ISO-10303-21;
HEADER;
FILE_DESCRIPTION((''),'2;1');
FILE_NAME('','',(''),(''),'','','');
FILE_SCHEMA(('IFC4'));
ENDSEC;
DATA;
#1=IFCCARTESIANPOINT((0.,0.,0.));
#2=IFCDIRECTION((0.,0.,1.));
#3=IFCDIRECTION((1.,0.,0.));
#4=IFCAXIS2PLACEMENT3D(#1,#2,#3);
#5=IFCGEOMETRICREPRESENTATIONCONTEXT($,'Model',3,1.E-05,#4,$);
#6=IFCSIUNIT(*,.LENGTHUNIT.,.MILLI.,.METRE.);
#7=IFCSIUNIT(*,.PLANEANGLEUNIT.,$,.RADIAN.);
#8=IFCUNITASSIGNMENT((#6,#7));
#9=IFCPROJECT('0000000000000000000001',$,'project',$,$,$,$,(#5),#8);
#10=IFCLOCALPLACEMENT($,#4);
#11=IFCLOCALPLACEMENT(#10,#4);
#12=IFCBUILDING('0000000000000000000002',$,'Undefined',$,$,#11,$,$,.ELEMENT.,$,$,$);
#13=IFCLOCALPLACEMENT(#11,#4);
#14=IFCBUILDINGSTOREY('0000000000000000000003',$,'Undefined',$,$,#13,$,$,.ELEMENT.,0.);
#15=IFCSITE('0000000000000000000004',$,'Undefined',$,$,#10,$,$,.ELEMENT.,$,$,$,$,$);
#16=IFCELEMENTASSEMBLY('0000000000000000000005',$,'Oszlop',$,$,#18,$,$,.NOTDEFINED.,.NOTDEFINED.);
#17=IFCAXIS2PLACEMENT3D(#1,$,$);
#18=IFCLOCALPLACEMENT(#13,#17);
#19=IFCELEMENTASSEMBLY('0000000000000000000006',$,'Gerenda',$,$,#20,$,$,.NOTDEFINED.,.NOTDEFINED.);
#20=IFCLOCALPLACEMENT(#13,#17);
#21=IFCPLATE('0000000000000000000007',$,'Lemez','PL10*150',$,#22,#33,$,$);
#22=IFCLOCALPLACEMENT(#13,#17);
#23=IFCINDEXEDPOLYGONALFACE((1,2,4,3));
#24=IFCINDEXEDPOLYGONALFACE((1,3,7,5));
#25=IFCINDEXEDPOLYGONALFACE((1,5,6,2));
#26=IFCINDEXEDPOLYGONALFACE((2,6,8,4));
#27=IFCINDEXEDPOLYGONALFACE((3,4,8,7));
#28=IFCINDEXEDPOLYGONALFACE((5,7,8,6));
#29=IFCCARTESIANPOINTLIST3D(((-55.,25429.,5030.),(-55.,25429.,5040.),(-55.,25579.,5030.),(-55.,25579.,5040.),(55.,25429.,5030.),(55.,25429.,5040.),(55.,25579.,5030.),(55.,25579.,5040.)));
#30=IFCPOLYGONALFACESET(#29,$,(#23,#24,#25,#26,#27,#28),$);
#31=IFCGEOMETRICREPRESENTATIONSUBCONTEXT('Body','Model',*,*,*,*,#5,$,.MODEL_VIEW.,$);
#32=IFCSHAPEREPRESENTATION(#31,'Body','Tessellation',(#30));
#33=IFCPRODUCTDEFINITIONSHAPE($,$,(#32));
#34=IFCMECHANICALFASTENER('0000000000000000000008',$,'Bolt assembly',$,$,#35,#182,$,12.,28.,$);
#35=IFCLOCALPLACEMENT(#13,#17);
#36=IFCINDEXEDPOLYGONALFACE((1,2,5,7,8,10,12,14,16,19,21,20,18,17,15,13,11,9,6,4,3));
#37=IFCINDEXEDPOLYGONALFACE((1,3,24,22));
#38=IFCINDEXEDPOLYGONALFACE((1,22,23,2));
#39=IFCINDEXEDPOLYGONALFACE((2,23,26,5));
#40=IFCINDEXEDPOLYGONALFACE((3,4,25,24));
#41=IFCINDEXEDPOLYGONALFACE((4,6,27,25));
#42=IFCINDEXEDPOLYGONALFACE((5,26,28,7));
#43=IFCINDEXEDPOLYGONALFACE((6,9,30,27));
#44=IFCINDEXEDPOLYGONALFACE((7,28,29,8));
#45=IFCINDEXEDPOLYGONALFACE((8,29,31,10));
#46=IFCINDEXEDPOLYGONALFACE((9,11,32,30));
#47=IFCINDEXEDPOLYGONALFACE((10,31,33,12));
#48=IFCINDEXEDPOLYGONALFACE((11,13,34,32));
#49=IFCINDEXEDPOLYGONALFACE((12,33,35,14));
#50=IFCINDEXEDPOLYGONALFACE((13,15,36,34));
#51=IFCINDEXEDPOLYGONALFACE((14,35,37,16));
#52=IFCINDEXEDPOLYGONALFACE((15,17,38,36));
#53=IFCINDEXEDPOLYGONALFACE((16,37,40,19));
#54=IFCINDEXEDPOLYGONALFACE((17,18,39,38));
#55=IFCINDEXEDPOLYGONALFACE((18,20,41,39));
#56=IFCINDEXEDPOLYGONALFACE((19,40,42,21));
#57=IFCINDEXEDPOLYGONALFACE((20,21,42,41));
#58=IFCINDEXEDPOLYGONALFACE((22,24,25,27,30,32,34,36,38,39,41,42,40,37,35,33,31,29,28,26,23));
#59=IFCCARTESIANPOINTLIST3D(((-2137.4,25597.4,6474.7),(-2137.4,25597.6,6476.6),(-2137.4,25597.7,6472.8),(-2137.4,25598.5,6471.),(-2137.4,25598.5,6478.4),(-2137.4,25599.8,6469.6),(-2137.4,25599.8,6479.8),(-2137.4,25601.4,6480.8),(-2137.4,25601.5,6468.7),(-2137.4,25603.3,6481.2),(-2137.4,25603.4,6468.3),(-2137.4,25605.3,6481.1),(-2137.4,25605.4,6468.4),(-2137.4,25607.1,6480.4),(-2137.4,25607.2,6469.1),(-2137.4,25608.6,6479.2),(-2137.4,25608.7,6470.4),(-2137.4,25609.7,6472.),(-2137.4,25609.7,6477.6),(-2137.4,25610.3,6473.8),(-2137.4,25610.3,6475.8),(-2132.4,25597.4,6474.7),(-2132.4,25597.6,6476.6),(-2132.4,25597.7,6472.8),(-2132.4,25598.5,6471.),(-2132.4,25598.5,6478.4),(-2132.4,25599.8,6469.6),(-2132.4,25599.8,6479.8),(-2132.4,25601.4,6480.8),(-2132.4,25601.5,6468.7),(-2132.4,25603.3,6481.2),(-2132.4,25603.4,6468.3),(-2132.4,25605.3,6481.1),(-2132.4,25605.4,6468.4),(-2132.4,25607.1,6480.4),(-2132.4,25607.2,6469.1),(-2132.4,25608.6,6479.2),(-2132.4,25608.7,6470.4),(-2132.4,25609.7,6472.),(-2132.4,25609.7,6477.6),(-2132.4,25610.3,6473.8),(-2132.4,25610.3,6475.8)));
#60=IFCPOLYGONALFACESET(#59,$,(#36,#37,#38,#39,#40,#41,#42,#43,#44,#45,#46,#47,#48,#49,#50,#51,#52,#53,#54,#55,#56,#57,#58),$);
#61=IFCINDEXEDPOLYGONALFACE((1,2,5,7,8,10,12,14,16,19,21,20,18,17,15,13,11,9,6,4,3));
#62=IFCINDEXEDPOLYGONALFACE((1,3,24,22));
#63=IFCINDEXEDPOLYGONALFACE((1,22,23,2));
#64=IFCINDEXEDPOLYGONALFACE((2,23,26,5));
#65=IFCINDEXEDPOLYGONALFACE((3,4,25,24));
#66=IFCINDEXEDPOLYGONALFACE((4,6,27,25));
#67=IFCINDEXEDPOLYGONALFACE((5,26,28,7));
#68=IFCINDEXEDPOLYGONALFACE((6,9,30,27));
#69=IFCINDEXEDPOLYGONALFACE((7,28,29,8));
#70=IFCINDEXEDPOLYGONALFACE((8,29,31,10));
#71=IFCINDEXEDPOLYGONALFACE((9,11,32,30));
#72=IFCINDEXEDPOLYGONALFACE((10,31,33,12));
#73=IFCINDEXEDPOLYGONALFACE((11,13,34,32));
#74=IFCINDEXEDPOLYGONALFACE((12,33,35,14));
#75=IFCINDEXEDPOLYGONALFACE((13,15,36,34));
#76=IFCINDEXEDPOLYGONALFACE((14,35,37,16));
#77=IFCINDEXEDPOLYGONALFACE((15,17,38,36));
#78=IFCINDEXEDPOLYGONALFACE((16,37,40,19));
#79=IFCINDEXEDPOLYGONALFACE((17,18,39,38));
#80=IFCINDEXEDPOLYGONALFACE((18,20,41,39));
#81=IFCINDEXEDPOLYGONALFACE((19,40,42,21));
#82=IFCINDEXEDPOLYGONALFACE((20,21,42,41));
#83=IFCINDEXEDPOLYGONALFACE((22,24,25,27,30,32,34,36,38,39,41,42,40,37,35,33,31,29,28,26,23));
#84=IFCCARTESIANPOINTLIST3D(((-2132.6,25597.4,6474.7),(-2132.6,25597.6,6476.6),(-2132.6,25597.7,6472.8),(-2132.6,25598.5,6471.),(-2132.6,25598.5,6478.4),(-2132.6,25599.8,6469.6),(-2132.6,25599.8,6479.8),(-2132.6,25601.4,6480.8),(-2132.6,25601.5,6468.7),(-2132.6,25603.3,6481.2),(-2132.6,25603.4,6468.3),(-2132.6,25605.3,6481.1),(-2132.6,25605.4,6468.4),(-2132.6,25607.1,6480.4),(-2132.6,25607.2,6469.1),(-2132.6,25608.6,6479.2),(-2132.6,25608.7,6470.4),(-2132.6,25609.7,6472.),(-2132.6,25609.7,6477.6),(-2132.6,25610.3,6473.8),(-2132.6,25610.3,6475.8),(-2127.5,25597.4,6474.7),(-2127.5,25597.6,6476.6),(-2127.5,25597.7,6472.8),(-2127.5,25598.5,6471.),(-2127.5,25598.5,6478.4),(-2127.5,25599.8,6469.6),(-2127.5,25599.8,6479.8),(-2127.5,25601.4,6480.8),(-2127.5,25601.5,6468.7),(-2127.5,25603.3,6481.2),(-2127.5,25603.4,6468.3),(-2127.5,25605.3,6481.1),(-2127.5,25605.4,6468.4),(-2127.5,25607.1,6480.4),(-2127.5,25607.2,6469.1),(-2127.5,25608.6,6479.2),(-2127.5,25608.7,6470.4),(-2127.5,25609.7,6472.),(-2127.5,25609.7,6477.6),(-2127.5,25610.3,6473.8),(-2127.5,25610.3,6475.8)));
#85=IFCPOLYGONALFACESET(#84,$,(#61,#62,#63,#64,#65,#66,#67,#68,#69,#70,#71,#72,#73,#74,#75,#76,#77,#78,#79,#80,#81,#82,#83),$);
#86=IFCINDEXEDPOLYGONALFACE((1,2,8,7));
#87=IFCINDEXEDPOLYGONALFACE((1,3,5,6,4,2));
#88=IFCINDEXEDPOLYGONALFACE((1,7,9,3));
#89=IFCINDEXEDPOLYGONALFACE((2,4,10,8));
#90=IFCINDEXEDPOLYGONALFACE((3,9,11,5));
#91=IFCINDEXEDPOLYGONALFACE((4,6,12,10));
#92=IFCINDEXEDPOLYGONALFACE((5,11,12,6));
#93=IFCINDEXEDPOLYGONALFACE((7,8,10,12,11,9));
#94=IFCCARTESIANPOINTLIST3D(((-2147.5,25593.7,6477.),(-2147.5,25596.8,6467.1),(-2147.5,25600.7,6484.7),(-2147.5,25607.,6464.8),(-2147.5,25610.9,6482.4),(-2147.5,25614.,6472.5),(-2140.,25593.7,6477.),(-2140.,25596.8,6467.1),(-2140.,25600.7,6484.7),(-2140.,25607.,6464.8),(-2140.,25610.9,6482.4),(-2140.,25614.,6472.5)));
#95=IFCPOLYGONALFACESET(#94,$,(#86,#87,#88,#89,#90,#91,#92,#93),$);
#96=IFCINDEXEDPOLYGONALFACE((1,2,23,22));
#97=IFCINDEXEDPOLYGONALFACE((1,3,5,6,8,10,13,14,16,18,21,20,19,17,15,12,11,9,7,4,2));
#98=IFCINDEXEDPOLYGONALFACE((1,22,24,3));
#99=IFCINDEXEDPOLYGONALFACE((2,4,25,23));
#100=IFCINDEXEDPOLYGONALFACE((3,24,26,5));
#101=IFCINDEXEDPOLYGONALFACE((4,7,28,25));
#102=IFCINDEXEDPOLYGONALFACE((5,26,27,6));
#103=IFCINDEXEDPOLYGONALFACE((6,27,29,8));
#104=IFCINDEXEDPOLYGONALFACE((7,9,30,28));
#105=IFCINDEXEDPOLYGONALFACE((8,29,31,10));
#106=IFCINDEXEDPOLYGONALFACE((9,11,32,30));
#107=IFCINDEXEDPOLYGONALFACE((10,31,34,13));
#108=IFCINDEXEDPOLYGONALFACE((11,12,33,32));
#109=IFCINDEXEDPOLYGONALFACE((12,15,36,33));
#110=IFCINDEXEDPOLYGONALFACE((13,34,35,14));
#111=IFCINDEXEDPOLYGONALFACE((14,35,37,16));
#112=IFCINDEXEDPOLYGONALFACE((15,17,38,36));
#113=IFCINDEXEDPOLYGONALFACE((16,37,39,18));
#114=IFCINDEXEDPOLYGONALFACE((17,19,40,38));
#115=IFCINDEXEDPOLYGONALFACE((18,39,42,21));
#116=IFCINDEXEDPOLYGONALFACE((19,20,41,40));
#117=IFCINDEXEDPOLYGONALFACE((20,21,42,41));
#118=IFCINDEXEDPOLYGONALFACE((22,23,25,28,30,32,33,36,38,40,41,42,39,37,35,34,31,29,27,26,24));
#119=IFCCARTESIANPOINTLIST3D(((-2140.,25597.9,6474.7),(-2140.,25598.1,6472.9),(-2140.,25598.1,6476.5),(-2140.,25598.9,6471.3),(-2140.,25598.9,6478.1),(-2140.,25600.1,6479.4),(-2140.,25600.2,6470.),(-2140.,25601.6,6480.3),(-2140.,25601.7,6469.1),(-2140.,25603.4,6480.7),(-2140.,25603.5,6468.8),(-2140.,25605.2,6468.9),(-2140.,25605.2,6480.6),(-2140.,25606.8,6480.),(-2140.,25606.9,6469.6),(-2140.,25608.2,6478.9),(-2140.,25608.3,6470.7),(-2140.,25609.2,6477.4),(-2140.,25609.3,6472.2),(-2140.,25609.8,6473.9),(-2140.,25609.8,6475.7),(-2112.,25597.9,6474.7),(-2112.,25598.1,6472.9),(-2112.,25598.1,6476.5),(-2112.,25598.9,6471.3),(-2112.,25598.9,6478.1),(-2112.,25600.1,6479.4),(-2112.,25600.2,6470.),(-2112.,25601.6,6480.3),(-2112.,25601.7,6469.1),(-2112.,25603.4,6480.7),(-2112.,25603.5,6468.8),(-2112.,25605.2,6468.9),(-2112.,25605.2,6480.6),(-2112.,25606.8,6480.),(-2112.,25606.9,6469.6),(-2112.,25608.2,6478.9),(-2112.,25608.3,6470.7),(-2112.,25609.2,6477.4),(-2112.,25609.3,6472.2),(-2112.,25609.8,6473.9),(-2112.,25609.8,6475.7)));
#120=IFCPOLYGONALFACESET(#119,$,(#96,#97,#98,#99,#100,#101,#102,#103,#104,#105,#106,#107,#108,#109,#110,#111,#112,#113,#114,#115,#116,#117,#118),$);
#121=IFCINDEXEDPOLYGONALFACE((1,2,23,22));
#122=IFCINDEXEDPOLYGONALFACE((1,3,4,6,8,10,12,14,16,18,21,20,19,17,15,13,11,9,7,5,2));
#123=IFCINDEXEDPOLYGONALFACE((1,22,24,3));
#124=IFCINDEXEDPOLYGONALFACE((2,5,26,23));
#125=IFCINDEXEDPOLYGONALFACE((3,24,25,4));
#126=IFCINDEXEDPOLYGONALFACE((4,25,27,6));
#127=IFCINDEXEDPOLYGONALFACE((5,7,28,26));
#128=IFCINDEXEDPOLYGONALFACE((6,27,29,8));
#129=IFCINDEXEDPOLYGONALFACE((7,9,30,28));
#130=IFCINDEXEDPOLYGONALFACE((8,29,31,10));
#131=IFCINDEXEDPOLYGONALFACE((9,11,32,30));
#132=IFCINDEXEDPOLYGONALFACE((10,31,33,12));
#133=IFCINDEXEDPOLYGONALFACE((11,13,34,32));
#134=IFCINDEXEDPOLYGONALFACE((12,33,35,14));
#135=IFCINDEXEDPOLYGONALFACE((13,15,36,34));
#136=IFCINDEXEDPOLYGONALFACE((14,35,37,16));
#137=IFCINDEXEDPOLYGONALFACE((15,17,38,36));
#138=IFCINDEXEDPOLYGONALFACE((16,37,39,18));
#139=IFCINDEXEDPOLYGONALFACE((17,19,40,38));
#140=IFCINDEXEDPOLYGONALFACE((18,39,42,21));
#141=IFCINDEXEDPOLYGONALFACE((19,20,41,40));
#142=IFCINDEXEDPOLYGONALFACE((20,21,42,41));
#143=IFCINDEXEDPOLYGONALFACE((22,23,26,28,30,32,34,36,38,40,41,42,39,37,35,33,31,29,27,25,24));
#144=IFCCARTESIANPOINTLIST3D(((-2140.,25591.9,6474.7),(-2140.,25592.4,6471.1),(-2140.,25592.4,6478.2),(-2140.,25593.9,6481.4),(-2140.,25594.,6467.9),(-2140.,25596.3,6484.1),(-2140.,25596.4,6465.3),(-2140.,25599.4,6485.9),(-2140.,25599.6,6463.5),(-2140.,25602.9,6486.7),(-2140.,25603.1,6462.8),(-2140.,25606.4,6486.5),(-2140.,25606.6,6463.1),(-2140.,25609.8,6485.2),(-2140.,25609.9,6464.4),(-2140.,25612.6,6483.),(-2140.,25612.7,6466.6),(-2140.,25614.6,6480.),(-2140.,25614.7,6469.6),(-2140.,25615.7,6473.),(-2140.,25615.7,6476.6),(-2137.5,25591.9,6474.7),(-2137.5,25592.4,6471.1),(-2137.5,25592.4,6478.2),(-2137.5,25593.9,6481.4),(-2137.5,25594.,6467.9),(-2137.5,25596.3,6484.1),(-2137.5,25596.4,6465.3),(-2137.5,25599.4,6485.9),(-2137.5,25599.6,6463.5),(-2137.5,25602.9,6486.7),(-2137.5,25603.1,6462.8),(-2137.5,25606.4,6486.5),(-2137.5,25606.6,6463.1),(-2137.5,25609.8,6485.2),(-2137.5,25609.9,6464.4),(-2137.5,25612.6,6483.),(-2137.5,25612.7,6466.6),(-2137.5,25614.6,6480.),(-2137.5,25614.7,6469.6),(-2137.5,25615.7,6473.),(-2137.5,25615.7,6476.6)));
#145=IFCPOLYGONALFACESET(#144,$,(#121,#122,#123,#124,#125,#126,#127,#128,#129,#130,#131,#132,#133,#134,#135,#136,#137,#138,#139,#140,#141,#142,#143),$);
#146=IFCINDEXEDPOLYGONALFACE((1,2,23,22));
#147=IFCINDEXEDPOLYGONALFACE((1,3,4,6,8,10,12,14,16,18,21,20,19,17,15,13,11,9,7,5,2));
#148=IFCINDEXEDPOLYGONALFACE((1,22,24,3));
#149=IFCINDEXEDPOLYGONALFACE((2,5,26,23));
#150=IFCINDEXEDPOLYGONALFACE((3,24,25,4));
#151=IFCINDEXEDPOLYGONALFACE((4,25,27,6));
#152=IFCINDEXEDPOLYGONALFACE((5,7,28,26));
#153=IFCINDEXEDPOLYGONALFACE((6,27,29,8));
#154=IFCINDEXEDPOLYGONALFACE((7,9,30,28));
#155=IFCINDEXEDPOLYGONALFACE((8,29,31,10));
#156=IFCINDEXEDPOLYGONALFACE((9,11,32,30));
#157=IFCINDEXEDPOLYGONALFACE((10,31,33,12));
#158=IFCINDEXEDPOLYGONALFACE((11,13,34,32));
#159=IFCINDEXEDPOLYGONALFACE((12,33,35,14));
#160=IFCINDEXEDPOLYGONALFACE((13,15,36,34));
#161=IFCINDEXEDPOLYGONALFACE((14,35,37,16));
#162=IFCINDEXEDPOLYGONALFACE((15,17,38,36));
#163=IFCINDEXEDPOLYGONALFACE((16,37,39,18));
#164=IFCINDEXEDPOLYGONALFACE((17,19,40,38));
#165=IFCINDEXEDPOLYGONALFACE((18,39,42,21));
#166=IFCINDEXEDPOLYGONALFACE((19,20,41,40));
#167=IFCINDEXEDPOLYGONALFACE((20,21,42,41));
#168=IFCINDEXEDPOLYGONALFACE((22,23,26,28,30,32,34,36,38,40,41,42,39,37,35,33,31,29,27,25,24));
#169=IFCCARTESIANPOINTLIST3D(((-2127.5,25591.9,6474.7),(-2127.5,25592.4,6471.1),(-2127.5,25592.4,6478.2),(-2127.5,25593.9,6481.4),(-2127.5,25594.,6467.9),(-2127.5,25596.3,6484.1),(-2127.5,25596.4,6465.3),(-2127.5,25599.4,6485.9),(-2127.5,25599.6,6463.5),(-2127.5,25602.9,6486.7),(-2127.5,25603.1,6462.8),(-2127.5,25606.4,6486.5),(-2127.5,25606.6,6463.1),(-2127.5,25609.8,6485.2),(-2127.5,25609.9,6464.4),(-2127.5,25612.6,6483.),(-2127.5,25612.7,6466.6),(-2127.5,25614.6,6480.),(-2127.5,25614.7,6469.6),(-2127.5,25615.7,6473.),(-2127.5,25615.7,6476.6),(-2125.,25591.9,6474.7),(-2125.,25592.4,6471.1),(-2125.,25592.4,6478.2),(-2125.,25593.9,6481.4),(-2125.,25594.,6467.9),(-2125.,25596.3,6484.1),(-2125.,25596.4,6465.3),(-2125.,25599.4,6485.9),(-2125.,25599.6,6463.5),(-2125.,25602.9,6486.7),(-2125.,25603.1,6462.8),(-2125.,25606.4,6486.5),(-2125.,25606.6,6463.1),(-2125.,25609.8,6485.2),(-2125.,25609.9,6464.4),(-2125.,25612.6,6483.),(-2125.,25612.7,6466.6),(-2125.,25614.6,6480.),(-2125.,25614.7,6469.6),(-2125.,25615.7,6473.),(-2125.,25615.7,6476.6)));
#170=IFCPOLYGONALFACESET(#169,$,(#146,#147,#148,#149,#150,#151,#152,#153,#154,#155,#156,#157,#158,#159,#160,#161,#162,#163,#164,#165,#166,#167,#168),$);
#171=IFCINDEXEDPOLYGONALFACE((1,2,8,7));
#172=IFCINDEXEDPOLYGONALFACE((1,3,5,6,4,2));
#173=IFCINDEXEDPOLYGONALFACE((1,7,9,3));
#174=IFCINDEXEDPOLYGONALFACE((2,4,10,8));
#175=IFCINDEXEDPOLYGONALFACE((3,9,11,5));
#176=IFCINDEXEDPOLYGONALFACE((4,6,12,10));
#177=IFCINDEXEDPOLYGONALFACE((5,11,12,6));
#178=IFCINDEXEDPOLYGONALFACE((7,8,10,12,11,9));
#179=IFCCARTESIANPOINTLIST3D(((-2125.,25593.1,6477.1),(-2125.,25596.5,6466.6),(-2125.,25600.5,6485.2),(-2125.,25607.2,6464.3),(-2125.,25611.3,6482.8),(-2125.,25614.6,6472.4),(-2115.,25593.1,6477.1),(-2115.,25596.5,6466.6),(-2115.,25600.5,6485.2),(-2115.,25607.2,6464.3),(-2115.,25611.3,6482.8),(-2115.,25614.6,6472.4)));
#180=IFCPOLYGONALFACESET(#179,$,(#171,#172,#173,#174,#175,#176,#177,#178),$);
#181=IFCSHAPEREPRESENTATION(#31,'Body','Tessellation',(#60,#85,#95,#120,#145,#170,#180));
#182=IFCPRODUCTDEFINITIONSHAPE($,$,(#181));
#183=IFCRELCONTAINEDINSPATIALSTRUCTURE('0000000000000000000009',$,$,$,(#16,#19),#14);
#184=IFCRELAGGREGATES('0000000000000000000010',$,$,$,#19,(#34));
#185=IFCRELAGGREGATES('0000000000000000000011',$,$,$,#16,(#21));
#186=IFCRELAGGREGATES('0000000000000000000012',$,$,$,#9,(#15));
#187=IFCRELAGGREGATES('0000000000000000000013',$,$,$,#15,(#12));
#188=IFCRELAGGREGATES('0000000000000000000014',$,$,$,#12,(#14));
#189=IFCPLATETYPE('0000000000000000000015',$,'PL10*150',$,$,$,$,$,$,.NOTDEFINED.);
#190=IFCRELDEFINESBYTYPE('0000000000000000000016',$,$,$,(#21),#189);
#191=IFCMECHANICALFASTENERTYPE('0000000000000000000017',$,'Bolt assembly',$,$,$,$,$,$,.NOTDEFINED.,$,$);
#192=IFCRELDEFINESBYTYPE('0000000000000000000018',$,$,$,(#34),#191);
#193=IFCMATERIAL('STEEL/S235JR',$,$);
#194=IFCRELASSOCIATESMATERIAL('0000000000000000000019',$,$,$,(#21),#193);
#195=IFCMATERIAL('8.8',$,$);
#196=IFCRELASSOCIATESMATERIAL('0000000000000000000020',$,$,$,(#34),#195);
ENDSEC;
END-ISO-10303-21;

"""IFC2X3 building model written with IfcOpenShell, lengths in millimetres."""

from ifc_helpers import new_model, si_unit, frame, origin_with_axes, origin_2d_with_axis, place, context, subcontext, project, spatial, polyline, circle, outline, extrude, source, transform, mapped, material, type_object, element, aggregate, save


model = new_model("IFC2X3")

# Units and contexts
model_context = context("Model", 3, precision=1e-05, world=origin_with_axes())
body_context = subcontext(model_context, "Body", "Model", "MODEL_VIEW")
ifc_project = project(units=[si_unit("LENGTHUNIT", "METRE", prefix="MILLI"), si_unit("PLANEANGLEUNIT", "RADIAN")], contexts=[model_context])

# Site, building, storey
site_placement = place(None, origin_with_axes())
site = spatial("IfcSite", under=ifc_project, at=site_placement, Name="Undefined", CompositionType="ELEMENT")
building_placement = place(site_placement, origin_with_axes())
building = spatial("IfcBuilding", under=site, at=building_placement, Name="Undefined", CompositionType="ELEMENT")
storey_placement = place(building_placement, origin_with_axes())
storey = spatial("IfcBuildingStorey", under=building, at=storey_placement, Name="Undefined", CompositionType="ELEMENT", Elevation=0.0)

# Element assembly
ifc_material_1 = material(Name="STEEL/S235JR")
assembly_1_placement = place(storey_placement, origin_with_axes())
assembly_1 = element("IfcElementAssembly", 1, at=assembly_1_placement, inside=storey, Name="Oszlop", AssemblyPlace="NOTDEFINED", PredefinedType="NOTDEFINED")

# Element assembly
assembly_2_placement = place(storey_placement, origin_with_axes())
assembly_2 = element("IfcElementAssembly", 2, at=assembly_2_placement, inside=storey, Name="Gerenda", AssemblyPlace="NOTDEFINED", PredefinedType="NOTDEFINED")

# Plate
plate_type_1 = type_object("IfcPlateType", Name="PL10*150", PredefinedType="NOTDEFINED")
plate_1_placement = place(assembly_1_placement, frame((55.0, 25504.0, 5035.0), z_axis=(0.0, 0.0, 1.0), x_axis=(-1.0, 0.0, 0.0)))
plate_1 = element("IfcPlate", 3, at=plate_1_placement, type_object=plate_type_1, material=ifc_material_1, Name="Lemez", Description="PL10*150", context=body_context, shape_type="SweptSolid", body=[
    extrude(outline(polyline([(0.0, -75.0), (0.0, 75.0), (110.0, 75.0), (110.0, -75.0), (0.0, -75.0)])), frame((0.0, 0.0, -5.0), z_axis=(0.0, 0.0, 1.0), x_axis=(1.0, 0.0, 0.0)), (0.0, 0.0, 1.0), 10.0),
])

# Mechanical fastener
ifc_material_2 = material(Name="8.8")
mechanical_fastener_type = type_object("IfcMechanicalFastenerType", Name="Bolt assembly")
shared_shape_1 = source(origin_with_axes(), body_context, "Body", "SweptSolid", [
    extrude(circle(Radius=6.5, at=origin_2d_with_axis()), frame((0.0, -7.4, 0.0), z_axis=(0.0, 1.0, 0.0), x_axis=(1.0, 0.0, 0.0)), (0.0, 0.0, 1.0), 5.0),
    extrude(circle(Radius=6.5, at=origin_2d_with_axis()), frame((0.0, -2.6, 0.0), z_axis=(0.0, 1.0, 0.0), x_axis=(1.0, 0.0, 0.0)), (0.0, 0.0, 1.0), 5.1),
    extrude(outline(polyline([(9.0, -5.2), (9.0, 5.2), (0.0, 10.4), (-9.0, 5.2), (-9.0, -5.2), (0.0, -10.4), (9.0, -5.2)])), frame((0.0, -17.5, 0.0), z_axis=(0.0, 1.0, 0.0), x_axis=(1.0, 0.0, 0.0)), (0.0, 0.0, 1.0), 7.5),
    extrude(circle(Radius=6.0, at=origin_2d_with_axis()), frame((0.0, -10.0, 0.0), z_axis=(0.0, 1.0, 0.0), x_axis=(1.0, 0.0, 0.0)), (0.0, 0.0, 1.0), 28.0),
    extrude(circle(Radius=12.0, at=origin_2d_with_axis()), frame((0.0, -10.0, 0.0), z_axis=(0.0, 1.0, 0.0), x_axis=(1.0, 0.0, 0.0)), (0.0, 0.0, 1.0), 2.5),
    extrude(circle(Radius=12.0, at=origin_2d_with_axis()), frame((0.0, 2.5, 0.0), z_axis=(0.0, 1.0, 0.0), x_axis=(1.0, 0.0, 0.0)), (0.0, 0.0, 1.0), 2.5),
    extrude(outline(polyline([(9.5, -5.5), (9.5, 5.5), (0.0, 11.0), (-9.5, 5.5), (-9.5, -5.5), (0.0, -11.0), (9.5, -5.5)])), frame((0.0, 5.0, 0.0), z_axis=(0.0, 1.0, 0.0), x_axis=(1.0, 0.0, 0.0)), (0.0, 0.0, 1.0), 10.0),
])
mechanical_fastener_1_placement = place(assembly_2_placement, frame((-2130.0, 25603.9, 6474.7), z_axis=(0.0, -0.674627, -0.738159), x_axis=(0.000003, 0.738159, -0.674627)))
mechanical_fastener_1 = element("IfcMechanicalFastener", 4, at=mechanical_fastener_1_placement, type_object=mechanical_fastener_type, material=ifc_material_2, Name="Bolt assembly", NominalDiameter=12.0, NominalLength=28.0, context=body_context, shape_type="MappedRepresentation", body=[
    mapped(shared_shape_1, transform((0.0, 0.0, 0.0))),
])
aggregate(assembly_2, [mechanical_fastener_1])
aggregate(assembly_1, [plate_1])

save(model, "model.ifc")
